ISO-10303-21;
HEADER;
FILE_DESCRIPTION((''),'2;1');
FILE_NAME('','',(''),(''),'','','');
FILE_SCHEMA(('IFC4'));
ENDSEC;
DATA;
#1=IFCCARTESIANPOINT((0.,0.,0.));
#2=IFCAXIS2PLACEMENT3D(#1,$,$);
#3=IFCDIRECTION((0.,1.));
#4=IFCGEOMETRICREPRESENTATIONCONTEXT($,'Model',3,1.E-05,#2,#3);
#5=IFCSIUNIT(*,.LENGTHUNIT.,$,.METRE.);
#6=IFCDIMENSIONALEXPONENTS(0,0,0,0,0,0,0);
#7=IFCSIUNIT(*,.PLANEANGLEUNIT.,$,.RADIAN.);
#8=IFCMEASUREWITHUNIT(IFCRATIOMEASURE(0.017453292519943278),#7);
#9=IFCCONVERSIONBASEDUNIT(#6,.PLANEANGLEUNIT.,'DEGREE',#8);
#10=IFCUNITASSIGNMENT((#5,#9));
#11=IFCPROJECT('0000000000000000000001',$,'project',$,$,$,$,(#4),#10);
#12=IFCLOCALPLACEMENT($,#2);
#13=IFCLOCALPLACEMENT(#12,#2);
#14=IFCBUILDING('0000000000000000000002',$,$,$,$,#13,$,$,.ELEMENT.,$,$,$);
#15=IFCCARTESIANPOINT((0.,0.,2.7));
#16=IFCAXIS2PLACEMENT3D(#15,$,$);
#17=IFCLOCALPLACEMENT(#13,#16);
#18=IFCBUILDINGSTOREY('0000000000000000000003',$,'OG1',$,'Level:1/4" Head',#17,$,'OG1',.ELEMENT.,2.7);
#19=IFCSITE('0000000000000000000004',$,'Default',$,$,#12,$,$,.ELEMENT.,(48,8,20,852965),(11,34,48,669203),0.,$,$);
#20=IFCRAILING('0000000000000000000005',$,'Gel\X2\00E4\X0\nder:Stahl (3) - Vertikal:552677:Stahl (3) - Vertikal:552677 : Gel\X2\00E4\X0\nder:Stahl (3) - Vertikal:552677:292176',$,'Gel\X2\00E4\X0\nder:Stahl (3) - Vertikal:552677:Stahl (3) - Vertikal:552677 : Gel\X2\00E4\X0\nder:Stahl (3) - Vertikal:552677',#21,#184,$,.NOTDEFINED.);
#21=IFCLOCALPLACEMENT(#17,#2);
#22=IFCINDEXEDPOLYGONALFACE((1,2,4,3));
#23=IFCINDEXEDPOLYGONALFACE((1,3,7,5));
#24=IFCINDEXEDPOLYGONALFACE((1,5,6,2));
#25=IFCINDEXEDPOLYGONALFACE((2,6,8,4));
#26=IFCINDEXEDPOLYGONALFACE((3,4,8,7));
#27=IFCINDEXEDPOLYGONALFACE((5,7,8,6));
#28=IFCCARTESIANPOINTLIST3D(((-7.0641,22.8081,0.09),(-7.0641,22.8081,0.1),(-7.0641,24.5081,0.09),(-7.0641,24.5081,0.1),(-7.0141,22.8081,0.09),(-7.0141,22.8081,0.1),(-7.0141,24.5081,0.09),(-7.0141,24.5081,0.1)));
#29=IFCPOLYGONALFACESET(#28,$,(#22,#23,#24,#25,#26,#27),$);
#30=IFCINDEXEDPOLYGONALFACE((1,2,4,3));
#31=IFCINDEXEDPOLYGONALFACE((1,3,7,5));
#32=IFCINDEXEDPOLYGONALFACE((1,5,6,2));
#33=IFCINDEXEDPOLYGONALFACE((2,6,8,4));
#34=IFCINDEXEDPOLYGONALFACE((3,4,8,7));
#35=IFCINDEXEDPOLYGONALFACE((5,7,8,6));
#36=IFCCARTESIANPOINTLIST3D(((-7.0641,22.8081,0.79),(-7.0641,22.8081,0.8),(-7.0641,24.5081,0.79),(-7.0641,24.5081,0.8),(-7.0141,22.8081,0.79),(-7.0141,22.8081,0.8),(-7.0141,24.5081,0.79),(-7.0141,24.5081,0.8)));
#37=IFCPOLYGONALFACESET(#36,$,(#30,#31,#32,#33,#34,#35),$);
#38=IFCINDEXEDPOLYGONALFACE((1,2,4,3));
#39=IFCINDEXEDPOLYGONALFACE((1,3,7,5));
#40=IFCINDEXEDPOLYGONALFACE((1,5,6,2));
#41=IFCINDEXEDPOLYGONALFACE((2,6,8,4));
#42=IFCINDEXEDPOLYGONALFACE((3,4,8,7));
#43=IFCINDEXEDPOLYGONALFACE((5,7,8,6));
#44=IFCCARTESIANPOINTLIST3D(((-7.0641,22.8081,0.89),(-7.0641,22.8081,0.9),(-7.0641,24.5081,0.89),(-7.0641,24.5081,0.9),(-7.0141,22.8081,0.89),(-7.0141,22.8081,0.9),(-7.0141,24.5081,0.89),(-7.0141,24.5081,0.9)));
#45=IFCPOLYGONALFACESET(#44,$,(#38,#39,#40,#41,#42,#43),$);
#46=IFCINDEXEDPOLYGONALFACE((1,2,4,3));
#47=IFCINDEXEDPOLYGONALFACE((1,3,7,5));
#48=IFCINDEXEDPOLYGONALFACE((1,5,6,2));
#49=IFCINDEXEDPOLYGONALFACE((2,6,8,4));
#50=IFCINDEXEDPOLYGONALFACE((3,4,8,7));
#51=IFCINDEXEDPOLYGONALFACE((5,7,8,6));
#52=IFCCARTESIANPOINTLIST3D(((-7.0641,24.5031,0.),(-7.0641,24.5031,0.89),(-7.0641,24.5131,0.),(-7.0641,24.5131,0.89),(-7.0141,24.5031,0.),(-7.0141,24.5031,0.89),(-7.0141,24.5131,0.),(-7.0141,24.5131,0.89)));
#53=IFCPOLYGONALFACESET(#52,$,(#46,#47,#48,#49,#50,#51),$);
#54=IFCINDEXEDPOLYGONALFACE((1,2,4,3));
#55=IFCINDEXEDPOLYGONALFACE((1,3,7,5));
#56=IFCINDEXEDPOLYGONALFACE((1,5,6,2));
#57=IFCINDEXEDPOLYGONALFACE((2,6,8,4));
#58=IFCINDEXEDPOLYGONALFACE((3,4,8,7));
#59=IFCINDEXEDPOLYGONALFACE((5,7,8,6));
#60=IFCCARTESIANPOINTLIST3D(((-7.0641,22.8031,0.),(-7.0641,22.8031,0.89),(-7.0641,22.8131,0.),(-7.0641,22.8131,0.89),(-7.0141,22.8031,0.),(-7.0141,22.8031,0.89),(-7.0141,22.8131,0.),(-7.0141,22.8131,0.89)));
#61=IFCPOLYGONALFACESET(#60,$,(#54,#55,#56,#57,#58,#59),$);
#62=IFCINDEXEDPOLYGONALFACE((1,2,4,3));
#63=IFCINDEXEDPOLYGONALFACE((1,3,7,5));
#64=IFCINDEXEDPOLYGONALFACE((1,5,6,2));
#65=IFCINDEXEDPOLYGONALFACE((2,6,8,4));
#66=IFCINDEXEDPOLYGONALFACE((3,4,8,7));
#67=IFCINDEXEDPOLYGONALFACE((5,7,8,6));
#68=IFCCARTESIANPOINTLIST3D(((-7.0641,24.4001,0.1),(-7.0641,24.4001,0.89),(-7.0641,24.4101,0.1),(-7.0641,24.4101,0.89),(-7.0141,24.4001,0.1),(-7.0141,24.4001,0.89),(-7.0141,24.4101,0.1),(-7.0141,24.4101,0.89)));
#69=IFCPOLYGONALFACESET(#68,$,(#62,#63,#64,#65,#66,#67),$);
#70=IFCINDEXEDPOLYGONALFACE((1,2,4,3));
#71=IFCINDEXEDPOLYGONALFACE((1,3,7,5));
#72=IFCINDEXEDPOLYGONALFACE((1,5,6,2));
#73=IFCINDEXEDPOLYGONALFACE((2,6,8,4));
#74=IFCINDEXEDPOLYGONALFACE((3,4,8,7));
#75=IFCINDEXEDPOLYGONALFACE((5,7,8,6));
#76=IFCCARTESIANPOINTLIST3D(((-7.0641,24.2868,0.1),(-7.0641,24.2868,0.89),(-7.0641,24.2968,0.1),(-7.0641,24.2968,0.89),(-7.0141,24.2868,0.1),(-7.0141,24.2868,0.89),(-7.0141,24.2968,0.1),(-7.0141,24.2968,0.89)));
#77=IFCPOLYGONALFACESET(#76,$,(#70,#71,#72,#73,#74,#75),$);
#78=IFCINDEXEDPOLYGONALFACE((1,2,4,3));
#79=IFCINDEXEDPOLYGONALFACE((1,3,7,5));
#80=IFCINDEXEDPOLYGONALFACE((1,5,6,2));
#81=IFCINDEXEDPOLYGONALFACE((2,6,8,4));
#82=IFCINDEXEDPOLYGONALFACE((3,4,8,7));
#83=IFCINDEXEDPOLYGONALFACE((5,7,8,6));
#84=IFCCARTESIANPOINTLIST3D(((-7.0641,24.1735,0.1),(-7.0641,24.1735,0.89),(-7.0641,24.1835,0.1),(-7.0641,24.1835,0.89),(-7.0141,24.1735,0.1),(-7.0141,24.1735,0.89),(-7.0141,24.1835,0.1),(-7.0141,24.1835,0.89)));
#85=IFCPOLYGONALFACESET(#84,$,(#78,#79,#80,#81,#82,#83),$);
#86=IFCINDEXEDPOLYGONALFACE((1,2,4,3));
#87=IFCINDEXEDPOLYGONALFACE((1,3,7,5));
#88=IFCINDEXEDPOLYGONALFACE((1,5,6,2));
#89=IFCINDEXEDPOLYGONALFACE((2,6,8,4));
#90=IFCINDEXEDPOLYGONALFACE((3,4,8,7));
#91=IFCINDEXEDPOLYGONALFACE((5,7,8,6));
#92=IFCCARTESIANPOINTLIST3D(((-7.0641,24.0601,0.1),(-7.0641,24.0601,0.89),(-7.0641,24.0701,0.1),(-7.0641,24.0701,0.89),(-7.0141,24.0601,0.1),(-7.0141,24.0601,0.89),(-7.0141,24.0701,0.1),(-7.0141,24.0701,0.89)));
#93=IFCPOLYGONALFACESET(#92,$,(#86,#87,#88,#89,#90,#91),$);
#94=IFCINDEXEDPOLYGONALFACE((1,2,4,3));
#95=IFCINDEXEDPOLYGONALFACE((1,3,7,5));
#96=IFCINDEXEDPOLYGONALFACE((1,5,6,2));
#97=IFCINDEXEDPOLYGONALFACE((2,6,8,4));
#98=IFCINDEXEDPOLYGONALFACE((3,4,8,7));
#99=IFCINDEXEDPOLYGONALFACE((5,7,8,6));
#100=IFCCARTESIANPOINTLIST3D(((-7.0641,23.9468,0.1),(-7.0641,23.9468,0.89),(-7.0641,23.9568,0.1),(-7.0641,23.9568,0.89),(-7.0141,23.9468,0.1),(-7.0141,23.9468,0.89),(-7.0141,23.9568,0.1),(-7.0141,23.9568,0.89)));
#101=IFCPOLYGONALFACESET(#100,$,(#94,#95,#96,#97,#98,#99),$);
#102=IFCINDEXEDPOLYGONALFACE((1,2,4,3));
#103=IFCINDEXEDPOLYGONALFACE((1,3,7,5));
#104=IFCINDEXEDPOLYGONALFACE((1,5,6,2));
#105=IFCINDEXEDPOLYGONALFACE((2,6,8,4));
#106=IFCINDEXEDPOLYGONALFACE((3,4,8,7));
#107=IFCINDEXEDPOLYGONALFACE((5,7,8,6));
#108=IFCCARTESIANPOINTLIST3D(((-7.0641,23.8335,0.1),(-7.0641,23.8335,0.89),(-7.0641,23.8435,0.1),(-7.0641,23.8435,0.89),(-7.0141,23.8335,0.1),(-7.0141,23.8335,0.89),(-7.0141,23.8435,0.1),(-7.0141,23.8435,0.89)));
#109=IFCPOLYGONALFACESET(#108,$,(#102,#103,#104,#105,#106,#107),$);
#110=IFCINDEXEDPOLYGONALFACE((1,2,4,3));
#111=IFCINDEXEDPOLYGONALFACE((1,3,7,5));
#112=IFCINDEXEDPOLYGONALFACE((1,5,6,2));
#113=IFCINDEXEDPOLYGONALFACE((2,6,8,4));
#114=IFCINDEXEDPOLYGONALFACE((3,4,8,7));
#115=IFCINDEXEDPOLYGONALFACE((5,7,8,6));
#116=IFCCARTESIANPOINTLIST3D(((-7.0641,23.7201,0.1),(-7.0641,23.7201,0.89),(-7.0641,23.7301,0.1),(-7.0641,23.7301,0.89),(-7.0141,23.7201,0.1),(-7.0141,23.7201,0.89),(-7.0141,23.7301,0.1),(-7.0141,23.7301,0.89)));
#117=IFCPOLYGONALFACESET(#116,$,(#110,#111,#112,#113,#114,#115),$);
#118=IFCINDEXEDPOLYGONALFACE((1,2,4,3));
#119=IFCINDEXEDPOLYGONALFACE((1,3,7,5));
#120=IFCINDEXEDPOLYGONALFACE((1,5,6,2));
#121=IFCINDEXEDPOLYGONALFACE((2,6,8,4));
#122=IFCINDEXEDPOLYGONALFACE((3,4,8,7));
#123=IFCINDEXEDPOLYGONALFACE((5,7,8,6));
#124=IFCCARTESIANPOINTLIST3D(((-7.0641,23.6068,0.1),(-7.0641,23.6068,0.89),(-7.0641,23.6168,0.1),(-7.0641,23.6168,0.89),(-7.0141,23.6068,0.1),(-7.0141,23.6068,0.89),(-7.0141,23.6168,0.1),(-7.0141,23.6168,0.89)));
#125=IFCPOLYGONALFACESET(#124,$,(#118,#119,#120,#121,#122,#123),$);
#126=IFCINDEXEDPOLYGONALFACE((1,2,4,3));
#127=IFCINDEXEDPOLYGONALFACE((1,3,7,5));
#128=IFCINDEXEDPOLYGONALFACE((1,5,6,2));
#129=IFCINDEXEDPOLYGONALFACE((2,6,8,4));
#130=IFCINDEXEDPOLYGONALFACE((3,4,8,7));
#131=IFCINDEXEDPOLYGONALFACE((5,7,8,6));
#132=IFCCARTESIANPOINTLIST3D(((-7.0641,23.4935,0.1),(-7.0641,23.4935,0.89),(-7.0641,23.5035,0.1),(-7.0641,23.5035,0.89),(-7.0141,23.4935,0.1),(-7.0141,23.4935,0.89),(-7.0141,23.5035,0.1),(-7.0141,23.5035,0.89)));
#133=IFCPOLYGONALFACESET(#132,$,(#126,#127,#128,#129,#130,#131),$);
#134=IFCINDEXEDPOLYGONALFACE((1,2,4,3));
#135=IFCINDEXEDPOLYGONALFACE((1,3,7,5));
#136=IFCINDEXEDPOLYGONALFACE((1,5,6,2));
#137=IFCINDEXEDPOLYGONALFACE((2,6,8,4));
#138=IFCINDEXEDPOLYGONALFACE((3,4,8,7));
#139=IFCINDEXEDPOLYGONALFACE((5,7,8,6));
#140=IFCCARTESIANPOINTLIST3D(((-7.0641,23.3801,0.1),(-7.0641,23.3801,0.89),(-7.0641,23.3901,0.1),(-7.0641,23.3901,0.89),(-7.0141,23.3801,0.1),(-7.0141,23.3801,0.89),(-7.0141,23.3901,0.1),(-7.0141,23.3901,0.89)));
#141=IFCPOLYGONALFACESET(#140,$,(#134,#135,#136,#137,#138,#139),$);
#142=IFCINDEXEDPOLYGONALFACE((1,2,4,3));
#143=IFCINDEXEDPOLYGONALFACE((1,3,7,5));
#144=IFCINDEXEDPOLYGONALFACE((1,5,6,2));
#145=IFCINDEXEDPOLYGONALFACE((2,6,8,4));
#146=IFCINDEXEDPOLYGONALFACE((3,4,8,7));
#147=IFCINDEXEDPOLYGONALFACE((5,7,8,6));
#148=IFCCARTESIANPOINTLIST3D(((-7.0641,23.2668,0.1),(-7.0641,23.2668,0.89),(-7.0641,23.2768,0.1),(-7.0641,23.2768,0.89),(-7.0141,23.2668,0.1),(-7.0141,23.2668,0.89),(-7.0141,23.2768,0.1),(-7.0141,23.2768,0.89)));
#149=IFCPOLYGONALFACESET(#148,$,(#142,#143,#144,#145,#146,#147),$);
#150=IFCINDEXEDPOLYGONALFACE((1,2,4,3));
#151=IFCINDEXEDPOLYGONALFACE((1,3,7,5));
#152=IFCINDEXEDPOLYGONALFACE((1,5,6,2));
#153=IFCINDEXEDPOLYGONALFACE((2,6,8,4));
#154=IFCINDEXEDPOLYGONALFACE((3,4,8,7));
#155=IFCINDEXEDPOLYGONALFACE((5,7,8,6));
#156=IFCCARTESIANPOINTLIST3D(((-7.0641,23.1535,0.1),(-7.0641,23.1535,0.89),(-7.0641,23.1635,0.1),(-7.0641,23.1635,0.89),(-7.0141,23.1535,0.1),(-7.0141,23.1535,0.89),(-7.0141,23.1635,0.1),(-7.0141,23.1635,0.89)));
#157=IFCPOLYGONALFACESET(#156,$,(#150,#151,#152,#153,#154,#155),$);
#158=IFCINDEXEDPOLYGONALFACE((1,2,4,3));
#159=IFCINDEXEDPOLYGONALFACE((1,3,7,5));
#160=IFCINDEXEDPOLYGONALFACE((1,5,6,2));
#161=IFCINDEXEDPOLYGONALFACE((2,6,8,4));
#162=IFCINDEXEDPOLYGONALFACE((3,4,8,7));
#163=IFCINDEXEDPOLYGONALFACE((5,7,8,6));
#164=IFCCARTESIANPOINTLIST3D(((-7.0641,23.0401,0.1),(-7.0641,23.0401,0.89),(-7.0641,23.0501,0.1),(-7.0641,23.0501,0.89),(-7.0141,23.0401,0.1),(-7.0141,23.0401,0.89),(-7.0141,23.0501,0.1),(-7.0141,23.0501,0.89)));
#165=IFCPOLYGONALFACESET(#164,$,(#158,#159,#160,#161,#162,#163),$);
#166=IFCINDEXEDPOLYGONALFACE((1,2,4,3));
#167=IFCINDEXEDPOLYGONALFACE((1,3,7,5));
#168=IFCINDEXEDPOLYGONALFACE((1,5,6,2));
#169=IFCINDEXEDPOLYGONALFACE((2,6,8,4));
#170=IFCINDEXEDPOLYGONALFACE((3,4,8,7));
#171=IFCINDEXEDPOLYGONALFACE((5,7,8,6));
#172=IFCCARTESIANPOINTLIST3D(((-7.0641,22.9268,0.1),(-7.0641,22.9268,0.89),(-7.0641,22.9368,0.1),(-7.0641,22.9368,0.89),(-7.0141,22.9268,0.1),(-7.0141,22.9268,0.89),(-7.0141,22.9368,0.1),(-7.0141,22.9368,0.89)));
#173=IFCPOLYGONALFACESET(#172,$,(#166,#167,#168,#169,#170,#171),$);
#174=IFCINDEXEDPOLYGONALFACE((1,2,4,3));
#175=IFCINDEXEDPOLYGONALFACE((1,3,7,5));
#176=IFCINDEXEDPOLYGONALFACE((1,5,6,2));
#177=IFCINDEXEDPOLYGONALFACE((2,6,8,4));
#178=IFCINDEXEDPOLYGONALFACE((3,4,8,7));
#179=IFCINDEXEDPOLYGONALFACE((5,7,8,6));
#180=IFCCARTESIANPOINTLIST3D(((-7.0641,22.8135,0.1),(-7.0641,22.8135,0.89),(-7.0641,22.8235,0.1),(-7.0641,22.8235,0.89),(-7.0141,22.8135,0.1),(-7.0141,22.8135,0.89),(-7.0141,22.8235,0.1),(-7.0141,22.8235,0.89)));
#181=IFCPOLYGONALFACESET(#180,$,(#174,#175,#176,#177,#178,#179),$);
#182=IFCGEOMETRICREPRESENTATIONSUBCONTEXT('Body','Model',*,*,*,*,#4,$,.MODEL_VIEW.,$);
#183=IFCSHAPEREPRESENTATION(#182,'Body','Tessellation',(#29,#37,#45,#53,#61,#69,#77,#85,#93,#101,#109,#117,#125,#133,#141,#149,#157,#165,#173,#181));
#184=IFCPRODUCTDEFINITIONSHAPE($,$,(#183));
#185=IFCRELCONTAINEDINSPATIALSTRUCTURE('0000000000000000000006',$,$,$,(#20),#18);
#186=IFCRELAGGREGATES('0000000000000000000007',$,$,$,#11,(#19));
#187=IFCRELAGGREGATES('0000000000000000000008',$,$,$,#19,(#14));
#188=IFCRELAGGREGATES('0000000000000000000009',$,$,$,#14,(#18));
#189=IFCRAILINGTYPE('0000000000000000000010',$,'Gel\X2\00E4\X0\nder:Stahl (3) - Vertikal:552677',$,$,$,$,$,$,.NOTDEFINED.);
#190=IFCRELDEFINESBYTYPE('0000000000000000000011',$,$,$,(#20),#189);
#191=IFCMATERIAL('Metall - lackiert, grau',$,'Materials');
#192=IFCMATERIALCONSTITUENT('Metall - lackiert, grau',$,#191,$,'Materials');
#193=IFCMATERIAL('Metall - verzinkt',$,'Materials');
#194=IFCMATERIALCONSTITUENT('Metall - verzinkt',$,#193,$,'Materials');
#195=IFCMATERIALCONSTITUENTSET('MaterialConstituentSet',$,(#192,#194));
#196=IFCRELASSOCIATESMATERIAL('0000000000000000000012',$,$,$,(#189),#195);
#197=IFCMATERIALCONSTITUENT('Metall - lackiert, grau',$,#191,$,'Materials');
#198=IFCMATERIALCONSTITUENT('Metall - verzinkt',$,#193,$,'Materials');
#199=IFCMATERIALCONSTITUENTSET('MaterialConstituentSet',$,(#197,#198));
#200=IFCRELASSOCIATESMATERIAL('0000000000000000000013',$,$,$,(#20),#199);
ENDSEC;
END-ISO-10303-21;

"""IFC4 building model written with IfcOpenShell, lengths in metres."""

from ifc_helpers import new_model, entity, si_unit, converted_unit, direction, frame, origin, place, context, subcontext, project, spatial, indexed_curve, outline, extrude, source, transform, mapped, material, constituent, constituent_set, type_object, type_shapes, element, save


model = new_model("IFC4")

# Units and contexts
model_context = context("Model", 3, precision=1e-05, world=origin(), true_north=direction((0.0, 1.0)))
body_context = subcontext(model_context, "Body", "Model", "MODEL_VIEW")
ifc_project = project(units=[si_unit("LENGTHUNIT", "METRE"), converted_unit("PLANEANGLEUNIT", "DEGREE", entity("IfcRatioMeasure", 0.017453292519943278), si_unit("PLANEANGLEUNIT", "RADIAN"), dimensions=[0, 0, 0, 0, 0, 0, 0])], contexts=[model_context])

# Site, building, storey
site_placement = place(None, origin())
site = spatial("IfcSite", under=ifc_project, at=site_placement, Name="Default", CompositionType="ELEMENT", RefLatitude=(48, 8, 20, 852965), RefLongitude=(11, 34, 48, 669203), RefElevation=0.0)
building_placement = place(site_placement, origin())
building = spatial("IfcBuilding", under=site, at=building_placement, CompositionType="ELEMENT")
storey_placement = place(building_placement, frame((0.0, 0.0, 2.7)))
storey = spatial("IfcBuildingStorey", under=building, at=storey_placement, Name="OG1", ObjectType="Level:1/4\" Head", LongName="OG1", CompositionType="ELEMENT", Elevation=2.7)

# Railing
ifc_material_1 = material(Name="Metall - lackiert, grau", Category="Materials")
ifc_material_2 = material(Name="Metall - verzinkt", Category="Materials")
ifc_constituent_1 = constituent(ifc_material_1, Name="Metall - lackiert, grau", Category="Materials")
ifc_constituent_2 = constituent(ifc_material_2, Name="Metall - verzinkt", Category="Materials")
ifc_constituent_set_1 = constituent_set(constituents=[ifc_constituent_1, ifc_constituent_2], Name="MaterialConstituentSet")
ifc_constituent_3 = constituent(ifc_material_1, Name="Metall - lackiert, grau", Category="Materials")
ifc_constituent_4 = constituent(ifc_material_2, Name="Metall - verzinkt", Category="Materials")
ifc_constituent_set_2 = constituent_set(constituents=[ifc_constituent_3, ifc_constituent_4], Name="MaterialConstituentSet")
railing_type_1 = type_object("IfcRailingType", Name="Geländer:Stahl (3) - Vertikal:552677", PredefinedType="NOTDEFINED", material=ifc_constituent_set_2)
shared_shape_1 = source(origin(), body_context, "Body", "SweptSolid", [
    extrude(outline(indexed_curve([(-0.025, -0.85), (0.025, -0.85), (0.025, 0.85), (-0.025, 0.85), (-0.025, -0.85)], self_intersect=False)), frame((-7.0391, 23.6581, 2.79)), (0.0, 0.0, 1.0), 0.01),
    extrude(outline(indexed_curve([(-0.025, -0.85), (0.025, -0.85), (0.025, 0.85), (-0.025, 0.85), (-0.025, -0.85)], self_intersect=False)), frame((-7.0391, 23.6581, 3.49)), (0.0, 0.0, 1.0), 0.01),
    extrude(outline(indexed_curve([(-0.025, -0.85), (0.025, -0.85), (0.025, 0.85), (-0.025, 0.85), (-0.025, -0.85)], self_intersect=False)), frame((-7.0391, 23.6581, 3.59)), (0.0, 0.0, 1.0), 0.01),
    extrude(outline(indexed_curve([(-0.025, -0.005), (0.025, -0.005), (0.025, 0.005), (-0.025, 0.005), (-0.025, -0.005)], self_intersect=False)), frame((-7.0391, 24.5081, 2.7)), (0.0, 0.0, 1.0), 0.89),
    extrude(outline(indexed_curve([(-0.025, -0.005), (0.025, -0.005), (0.025, 0.005), (-0.025, 0.005), (-0.025, -0.005)], self_intersect=False)), frame((-7.0391, 22.8081, 2.7)), (0.0, 0.0, 1.0), 0.89),
    extrude(outline(indexed_curve([(-0.025, -0.005), (0.025, -0.005), (0.025, 0.005), (-0.025, 0.005), (-0.025, -0.005)], self_intersect=False)), frame((-7.0391, 24.4051, 2.8)), (0.0, 0.0, 1.0), 0.79),
    extrude(outline(indexed_curve([(-0.025, -0.005), (0.025, -0.005), (0.025, 0.005), (-0.025, 0.005), (-0.025, -0.005)], self_intersect=False)), frame((-7.0391, 24.2918, 2.8)), (0.0, 0.0, 1.0), 0.79),
    extrude(outline(indexed_curve([(-0.025, -0.005), (0.025, -0.005), (0.025, 0.005), (-0.025, 0.005), (-0.025, -0.005)], self_intersect=False)), frame((-7.0391, 24.1785, 2.8)), (0.0, 0.0, 1.0), 0.79),
    extrude(outline(indexed_curve([(-0.025, -0.005), (0.025, -0.005), (0.025, 0.005), (-0.025, 0.005), (-0.025, -0.005)], self_intersect=False)), frame((-7.0391, 24.0651, 2.8)), (0.0, 0.0, 1.0), 0.79),
    extrude(outline(indexed_curve([(-0.025, -0.005), (0.025, -0.005), (0.025, 0.005), (-0.025, 0.005), (-0.025, -0.005)], self_intersect=False)), frame((-7.0391, 23.9518, 2.8)), (0.0, 0.0, 1.0), 0.79),
    extrude(outline(indexed_curve([(-0.025, -0.005), (0.025, -0.005), (0.025, 0.005), (-0.025, 0.005), (-0.025, -0.005)], self_intersect=False)), frame((-7.0391, 23.8385, 2.8)), (0.0, 0.0, 1.0), 0.79),
    extrude(outline(indexed_curve([(-0.025, -0.005), (0.025, -0.005), (0.025, 0.005), (-0.025, 0.005), (-0.025, -0.005)], self_intersect=False)), frame((-7.0391, 23.7251, 2.8)), (0.0, 0.0, 1.0), 0.79),
    extrude(outline(indexed_curve([(-0.025, -0.005), (0.025, -0.005), (0.025, 0.005), (-0.025, 0.005), (-0.025, -0.005)], self_intersect=False)), frame((-7.0391, 23.6118, 2.8)), (0.0, 0.0, 1.0), 0.79),
    extrude(outline(indexed_curve([(-0.025, -0.005), (0.025, -0.005), (0.025, 0.005), (-0.025, 0.005), (-0.025, -0.005)], self_intersect=False)), frame((-7.0391, 23.4985, 2.8)), (0.0, 0.0, 1.0), 0.79),
    extrude(outline(indexed_curve([(-0.025, -0.005), (0.025, -0.005), (0.025, 0.005), (-0.025, 0.005), (-0.025, -0.005)], self_intersect=False)), frame((-7.0391, 23.3851, 2.8)), (0.0, 0.0, 1.0), 0.79),
    extrude(outline(indexed_curve([(-0.025, -0.005), (0.025, -0.005), (0.025, 0.005), (-0.025, 0.005), (-0.025, -0.005)], self_intersect=False)), frame((-7.0391, 23.2718, 2.8)), (0.0, 0.0, 1.0), 0.79),
    extrude(outline(indexed_curve([(-0.025, -0.005), (0.025, -0.005), (0.025, 0.005), (-0.025, 0.005), (-0.025, -0.005)], self_intersect=False)), frame((-7.0391, 23.1585, 2.8)), (0.0, 0.0, 1.0), 0.79),
    extrude(outline(indexed_curve([(-0.025, -0.005), (0.025, -0.005), (0.025, 0.005), (-0.025, 0.005), (-0.025, -0.005)], self_intersect=False)), frame((-7.0391, 23.0451, 2.8)), (0.0, 0.0, 1.0), 0.79),
    extrude(outline(indexed_curve([(-0.025, -0.005), (0.025, -0.005), (0.025, 0.005), (-0.025, 0.005), (-0.025, -0.005)], self_intersect=False)), frame((-7.0391, 22.9318, 2.8)), (0.0, 0.0, 1.0), 0.79),
    extrude(outline(indexed_curve([(-0.025, -0.005), (0.025, -0.005), (0.025, 0.005), (-0.025, 0.005), (-0.025, -0.005)], self_intersect=False)), frame((-7.0391, 22.8185, 2.8)), (0.0, 0.0, 1.0), 0.79),
])
type_shapes(railing_type_1, [shared_shape_1])
railing_1_placement = place(storey_placement, frame((0.0, 0.0, -2.7)))
element("IfcRailing", 1, at=railing_1_placement, inside=storey, type_object=railing_type_1, material=ifc_constituent_set_1, Name="Geländer:Stahl (3) - Vertikal:552677:Stahl (3) - Vertikal:552677 : Geländer:Stahl (3) - Vertikal:552677:292176", ObjectType="Geländer:Stahl (3) - Vertikal:552677:Stahl (3) - Vertikal:552677 : Geländer:Stahl (3) - Vertikal:552677", PredefinedType="NOTDEFINED", context=body_context, shape_type="MappedRepresentation", body=[
    mapped(shared_shape_1, transform((0.0, 0.0, 0.0), scale=1.0)),
])

save(model, "model.ifc")
